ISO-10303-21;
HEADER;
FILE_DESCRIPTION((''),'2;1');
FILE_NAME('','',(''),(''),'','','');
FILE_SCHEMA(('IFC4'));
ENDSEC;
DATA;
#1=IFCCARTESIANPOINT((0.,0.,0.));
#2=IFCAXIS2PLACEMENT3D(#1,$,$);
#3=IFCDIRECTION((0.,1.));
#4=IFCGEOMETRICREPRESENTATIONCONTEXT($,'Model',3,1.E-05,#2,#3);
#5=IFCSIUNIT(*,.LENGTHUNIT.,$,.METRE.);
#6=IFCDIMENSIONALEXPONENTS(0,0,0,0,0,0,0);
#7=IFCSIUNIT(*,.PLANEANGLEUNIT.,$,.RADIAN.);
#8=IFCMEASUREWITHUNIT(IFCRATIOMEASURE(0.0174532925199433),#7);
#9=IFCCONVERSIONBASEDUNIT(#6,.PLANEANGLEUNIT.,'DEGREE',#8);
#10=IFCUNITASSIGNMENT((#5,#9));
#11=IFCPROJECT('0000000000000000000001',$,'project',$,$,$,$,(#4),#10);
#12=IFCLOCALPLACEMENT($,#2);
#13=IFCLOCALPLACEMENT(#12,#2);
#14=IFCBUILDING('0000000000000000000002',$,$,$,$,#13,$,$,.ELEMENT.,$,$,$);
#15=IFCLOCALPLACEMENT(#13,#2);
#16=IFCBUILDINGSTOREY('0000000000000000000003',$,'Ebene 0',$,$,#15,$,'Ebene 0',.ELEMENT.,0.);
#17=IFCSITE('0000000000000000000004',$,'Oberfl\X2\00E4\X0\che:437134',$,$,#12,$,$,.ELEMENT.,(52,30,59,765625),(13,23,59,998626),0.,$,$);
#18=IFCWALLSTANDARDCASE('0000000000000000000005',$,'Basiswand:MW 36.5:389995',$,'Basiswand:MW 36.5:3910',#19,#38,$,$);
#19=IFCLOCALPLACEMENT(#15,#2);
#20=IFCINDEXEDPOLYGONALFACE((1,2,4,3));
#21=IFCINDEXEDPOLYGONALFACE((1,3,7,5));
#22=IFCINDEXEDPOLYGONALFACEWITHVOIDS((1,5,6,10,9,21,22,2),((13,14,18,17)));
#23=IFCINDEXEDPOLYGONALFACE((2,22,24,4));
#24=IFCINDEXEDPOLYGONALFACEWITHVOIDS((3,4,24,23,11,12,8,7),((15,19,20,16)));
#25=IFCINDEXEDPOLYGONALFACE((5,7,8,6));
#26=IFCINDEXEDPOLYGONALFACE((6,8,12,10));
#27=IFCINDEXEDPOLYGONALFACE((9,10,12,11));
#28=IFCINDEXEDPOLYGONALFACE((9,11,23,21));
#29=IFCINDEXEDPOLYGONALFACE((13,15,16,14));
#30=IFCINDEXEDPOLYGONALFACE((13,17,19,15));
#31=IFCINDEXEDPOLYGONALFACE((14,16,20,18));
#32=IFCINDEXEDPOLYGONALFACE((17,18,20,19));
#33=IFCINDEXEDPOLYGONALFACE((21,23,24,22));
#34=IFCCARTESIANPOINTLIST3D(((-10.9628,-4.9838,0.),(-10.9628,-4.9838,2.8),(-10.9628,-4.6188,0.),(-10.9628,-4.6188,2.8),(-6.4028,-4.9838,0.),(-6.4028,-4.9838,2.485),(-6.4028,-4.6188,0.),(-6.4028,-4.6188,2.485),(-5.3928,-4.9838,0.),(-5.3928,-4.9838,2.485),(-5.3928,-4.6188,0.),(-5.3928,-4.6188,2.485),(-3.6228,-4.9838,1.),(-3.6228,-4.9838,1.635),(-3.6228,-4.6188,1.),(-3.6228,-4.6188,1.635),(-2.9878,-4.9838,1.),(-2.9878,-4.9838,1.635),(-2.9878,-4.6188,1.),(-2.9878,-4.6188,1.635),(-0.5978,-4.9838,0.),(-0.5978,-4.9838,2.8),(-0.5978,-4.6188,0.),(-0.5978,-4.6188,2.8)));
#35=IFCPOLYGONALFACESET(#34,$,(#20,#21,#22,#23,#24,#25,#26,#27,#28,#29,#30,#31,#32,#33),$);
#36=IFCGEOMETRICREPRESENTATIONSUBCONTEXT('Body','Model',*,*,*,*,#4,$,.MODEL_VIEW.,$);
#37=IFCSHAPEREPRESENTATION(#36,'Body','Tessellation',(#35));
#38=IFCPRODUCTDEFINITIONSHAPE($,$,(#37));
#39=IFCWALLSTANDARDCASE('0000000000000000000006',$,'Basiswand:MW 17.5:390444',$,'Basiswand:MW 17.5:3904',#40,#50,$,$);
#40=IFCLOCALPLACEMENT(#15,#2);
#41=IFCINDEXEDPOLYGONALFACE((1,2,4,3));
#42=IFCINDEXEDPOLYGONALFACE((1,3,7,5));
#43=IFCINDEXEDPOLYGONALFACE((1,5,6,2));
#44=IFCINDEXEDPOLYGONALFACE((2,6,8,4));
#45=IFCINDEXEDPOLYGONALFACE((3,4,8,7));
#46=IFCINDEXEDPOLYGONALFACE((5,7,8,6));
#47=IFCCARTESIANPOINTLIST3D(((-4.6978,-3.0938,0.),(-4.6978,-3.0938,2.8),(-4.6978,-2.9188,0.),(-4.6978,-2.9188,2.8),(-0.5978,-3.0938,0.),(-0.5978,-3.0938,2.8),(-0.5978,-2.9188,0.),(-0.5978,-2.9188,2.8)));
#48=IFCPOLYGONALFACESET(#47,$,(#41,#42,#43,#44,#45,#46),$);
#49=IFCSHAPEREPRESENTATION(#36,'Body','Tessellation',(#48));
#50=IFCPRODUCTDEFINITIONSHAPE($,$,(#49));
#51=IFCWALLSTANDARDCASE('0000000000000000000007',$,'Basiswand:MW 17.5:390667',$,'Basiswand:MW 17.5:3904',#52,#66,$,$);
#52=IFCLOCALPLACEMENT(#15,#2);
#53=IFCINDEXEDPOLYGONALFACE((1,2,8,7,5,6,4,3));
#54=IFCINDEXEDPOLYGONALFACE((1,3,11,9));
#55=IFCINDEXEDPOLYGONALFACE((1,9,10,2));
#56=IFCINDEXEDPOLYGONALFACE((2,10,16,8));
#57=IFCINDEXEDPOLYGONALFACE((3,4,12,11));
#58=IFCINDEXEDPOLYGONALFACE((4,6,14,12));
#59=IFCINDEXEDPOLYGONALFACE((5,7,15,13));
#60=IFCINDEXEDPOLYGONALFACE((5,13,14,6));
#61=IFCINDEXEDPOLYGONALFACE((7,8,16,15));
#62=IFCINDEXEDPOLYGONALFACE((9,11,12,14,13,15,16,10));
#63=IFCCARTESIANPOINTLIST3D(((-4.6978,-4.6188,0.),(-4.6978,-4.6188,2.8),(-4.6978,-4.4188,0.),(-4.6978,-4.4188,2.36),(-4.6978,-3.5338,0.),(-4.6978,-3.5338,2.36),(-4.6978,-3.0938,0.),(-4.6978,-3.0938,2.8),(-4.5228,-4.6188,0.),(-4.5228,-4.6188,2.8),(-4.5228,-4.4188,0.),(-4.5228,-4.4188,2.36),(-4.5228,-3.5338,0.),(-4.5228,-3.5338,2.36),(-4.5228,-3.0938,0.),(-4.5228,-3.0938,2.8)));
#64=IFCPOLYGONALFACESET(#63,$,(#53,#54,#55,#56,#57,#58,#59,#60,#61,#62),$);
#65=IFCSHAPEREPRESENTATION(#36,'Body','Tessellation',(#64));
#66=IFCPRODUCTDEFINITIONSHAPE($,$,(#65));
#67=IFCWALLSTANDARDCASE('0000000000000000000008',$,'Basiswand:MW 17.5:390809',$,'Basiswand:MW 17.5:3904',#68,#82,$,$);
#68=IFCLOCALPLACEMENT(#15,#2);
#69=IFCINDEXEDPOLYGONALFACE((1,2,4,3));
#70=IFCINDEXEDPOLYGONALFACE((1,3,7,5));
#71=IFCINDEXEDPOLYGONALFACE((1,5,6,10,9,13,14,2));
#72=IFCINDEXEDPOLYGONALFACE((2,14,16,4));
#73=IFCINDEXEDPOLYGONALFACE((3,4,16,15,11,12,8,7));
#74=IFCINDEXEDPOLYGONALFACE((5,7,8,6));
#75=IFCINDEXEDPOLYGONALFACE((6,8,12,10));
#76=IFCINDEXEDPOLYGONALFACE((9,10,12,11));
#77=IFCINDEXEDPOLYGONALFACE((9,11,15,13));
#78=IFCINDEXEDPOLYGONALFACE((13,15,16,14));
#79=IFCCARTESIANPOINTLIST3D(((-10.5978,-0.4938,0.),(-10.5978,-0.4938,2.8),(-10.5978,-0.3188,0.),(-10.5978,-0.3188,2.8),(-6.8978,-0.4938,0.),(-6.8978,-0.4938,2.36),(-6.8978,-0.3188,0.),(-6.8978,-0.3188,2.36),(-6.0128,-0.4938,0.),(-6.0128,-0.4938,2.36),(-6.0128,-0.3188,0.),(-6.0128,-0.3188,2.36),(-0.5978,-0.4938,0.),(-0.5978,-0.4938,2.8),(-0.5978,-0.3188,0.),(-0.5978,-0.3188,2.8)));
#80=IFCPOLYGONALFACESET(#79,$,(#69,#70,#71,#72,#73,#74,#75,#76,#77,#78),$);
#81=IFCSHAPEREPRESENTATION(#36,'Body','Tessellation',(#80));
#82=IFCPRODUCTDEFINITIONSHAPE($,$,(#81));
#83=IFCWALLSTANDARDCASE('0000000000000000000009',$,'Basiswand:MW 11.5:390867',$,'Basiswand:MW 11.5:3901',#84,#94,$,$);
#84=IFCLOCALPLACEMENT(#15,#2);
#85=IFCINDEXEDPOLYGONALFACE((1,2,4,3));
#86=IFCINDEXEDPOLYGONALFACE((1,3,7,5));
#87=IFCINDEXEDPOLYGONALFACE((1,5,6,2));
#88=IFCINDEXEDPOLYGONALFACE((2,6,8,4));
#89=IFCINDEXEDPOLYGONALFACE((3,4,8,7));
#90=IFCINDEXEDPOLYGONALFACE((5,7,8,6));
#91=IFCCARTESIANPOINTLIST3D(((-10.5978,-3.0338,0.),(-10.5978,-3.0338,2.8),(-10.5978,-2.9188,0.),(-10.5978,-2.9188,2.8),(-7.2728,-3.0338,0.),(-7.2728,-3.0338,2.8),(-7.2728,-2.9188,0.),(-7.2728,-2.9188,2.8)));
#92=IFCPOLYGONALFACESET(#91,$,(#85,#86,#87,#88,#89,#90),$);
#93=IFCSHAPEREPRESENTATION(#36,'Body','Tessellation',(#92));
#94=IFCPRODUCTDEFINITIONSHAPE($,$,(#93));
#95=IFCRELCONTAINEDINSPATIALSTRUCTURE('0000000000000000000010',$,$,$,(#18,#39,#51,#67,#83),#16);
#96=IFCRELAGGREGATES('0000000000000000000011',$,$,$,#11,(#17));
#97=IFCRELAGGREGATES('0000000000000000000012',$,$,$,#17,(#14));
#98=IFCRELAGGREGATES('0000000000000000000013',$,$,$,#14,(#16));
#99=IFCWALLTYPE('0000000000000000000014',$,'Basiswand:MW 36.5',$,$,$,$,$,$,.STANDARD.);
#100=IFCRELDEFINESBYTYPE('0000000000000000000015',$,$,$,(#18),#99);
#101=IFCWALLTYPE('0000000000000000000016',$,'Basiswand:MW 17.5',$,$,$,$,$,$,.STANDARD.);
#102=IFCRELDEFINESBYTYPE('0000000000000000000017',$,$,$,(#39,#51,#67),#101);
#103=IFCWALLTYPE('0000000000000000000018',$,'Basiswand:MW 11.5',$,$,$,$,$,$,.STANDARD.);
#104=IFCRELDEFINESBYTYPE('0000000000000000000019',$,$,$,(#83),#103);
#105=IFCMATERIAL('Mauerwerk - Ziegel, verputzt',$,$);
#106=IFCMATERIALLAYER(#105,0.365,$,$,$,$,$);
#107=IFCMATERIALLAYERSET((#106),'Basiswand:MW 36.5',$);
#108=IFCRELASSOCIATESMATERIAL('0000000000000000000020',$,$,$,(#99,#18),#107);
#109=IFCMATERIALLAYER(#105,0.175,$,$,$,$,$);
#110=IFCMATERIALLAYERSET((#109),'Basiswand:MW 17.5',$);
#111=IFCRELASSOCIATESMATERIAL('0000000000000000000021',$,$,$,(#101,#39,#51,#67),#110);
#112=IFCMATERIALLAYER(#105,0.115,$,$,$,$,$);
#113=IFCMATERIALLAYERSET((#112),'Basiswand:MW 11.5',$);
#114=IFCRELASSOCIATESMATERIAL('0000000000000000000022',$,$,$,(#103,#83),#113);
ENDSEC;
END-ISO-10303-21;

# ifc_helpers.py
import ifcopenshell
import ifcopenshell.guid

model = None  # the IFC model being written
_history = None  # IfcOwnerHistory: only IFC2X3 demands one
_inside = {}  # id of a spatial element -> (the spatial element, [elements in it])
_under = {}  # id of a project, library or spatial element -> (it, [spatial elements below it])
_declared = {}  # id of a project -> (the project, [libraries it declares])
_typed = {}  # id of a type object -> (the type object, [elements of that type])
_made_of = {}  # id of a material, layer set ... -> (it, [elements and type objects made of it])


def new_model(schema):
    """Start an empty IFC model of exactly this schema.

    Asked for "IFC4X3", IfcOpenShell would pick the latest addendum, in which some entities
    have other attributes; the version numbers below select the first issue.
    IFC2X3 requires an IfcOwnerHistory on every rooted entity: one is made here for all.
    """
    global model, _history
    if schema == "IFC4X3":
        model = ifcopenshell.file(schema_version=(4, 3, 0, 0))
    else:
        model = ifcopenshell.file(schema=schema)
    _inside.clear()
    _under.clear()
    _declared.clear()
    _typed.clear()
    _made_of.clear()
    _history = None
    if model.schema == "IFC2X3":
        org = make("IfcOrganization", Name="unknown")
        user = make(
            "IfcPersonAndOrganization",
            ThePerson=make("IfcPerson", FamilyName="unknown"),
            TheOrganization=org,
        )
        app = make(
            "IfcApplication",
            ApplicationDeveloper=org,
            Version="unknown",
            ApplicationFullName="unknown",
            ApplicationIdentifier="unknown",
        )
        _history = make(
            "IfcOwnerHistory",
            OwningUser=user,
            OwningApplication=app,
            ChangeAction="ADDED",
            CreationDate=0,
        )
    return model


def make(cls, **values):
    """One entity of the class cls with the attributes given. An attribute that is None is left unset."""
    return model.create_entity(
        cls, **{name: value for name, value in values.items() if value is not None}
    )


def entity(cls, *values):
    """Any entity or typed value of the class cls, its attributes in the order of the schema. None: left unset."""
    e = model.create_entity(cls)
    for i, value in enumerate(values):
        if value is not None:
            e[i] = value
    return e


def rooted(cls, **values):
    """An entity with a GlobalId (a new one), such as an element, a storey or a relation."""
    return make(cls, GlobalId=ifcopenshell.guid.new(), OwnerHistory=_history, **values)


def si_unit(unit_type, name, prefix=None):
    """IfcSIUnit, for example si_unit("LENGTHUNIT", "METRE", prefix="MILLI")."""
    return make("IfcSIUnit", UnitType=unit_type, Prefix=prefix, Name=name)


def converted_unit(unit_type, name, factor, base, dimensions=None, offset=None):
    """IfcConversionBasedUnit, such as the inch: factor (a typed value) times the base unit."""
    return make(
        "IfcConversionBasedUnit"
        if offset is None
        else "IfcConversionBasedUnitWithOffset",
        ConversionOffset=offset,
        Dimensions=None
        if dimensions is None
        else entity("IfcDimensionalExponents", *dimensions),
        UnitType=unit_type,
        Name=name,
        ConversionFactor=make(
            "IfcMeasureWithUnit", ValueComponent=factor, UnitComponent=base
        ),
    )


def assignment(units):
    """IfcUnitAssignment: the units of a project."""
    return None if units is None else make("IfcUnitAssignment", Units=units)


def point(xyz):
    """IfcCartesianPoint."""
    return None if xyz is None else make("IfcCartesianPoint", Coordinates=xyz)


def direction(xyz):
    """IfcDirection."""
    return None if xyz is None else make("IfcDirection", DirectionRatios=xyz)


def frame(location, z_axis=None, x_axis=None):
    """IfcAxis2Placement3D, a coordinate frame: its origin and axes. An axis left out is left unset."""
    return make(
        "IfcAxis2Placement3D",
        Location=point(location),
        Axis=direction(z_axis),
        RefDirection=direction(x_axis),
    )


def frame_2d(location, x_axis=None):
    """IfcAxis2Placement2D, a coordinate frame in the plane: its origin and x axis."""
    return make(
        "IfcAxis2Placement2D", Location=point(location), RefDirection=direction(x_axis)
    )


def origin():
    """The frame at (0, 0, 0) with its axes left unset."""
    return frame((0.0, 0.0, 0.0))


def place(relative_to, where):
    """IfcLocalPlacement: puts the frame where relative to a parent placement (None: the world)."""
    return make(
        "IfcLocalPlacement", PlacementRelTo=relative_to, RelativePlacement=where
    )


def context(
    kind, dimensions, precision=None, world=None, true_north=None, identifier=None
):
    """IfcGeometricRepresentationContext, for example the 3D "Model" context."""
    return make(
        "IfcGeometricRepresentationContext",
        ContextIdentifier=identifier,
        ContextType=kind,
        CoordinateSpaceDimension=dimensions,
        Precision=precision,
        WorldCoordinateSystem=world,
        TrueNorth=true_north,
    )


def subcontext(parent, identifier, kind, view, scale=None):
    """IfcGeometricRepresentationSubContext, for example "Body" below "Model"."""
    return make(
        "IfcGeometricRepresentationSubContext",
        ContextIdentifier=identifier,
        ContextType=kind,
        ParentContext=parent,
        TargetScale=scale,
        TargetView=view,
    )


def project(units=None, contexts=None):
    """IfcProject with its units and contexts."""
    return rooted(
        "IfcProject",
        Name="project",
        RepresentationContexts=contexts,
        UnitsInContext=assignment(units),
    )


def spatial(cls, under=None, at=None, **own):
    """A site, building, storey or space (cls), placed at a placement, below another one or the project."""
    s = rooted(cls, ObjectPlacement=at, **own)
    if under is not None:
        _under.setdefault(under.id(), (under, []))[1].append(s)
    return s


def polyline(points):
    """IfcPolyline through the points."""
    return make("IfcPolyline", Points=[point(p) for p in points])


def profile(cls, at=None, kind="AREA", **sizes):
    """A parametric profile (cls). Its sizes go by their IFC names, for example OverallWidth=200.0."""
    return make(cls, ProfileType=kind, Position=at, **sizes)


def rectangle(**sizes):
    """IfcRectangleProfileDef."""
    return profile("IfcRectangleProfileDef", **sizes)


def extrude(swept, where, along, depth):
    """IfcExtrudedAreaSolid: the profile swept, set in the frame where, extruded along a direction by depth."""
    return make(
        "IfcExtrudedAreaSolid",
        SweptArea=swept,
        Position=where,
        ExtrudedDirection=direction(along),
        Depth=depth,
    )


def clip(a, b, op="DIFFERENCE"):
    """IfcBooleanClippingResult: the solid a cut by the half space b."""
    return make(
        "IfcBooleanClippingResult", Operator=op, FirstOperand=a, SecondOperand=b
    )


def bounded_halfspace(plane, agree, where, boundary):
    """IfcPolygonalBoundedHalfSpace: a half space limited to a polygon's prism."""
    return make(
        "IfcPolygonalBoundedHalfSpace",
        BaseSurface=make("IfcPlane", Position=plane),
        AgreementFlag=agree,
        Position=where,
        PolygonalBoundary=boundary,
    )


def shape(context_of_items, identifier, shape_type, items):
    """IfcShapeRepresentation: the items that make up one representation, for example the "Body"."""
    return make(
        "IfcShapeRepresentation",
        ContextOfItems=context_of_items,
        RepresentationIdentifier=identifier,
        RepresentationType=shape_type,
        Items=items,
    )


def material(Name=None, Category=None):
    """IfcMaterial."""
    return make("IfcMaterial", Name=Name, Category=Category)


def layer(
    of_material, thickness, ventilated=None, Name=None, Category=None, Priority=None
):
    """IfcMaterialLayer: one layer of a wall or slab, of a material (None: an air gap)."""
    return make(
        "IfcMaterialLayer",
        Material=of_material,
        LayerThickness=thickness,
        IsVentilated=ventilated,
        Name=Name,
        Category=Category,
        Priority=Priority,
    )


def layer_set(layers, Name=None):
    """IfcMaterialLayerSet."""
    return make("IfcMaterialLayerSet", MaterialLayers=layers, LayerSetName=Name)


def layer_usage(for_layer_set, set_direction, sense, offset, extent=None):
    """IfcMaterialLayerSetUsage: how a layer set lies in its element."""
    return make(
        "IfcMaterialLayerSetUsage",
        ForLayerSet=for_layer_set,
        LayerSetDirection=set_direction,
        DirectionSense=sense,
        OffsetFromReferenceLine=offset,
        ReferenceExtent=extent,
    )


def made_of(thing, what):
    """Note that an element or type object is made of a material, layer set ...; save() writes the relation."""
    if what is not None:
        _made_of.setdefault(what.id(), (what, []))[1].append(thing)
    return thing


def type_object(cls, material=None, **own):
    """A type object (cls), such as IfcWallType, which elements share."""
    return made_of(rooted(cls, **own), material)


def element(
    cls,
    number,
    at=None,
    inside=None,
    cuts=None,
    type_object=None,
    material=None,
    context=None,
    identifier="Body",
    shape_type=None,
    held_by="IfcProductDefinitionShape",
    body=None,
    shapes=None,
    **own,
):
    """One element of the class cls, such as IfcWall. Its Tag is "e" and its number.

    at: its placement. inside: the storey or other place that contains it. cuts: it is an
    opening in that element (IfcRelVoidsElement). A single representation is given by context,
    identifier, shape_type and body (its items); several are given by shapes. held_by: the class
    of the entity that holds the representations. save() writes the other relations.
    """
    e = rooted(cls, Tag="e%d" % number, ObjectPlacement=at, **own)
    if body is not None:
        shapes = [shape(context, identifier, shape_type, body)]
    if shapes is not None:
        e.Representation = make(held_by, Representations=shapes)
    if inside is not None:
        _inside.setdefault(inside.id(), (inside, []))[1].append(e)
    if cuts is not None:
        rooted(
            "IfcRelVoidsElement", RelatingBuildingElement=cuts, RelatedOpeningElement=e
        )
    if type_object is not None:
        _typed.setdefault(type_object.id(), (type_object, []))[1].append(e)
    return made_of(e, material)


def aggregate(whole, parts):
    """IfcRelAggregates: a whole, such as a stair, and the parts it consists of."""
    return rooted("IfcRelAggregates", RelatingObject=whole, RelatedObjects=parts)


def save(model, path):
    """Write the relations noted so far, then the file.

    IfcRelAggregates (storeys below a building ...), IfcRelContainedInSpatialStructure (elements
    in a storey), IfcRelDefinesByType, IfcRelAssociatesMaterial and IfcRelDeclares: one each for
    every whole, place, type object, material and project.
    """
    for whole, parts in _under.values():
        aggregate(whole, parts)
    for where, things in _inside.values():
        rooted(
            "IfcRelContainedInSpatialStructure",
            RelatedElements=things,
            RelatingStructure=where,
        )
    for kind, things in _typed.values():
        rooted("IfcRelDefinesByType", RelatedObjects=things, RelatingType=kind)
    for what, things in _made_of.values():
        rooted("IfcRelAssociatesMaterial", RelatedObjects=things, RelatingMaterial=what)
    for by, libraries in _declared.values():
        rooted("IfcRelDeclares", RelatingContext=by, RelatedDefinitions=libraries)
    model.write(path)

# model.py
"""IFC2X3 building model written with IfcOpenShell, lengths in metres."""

from ifc_helpers import new_model, entity, si_unit, converted_unit, direction, frame, frame_2d, origin, place, context, subcontext, project, spatial, polyline, rectangle, extrude, clip, bounded_halfspace, material, layer, layer_set, layer_usage, type_object, element, save


model = new_model("IFC2X3")

# Units and contexts
model_context = context("Model", 3, precision=1e-05, world=origin(), true_north=direction((0.0, 1.0)))
body_context = subcontext(model_context, "Body", "Model", "MODEL_VIEW")
ifc_project = project(units=[si_unit("LENGTHUNIT", "METRE"), converted_unit("PLANEANGLEUNIT", "DEGREE", entity("IfcRatioMeasure", 0.0174532925199433), si_unit("PLANEANGLEUNIT", "RADIAN"), dimensions=[0, 0, 0, 0, 0, 0, 0])], contexts=[model_context])

# Site, building, storey
site_placement = place(None, origin())
site = spatial("IfcSite", under=ifc_project, at=site_placement, Name="Oberfläche:437134", CompositionType="ELEMENT", RefLatitude=(52, 30, 59, 765625), RefLongitude=(13, 23, 59, 998626), RefElevation=0.0)
building_placement = place(site_placement, origin())
building = spatial("IfcBuilding", under=site, at=building_placement, CompositionType="ELEMENT")
storey_placement = place(building_placement, origin())
storey = spatial("IfcBuildingStorey", under=building, at=storey_placement, Name="Ebene 0", LongName="Ebene 0", CompositionType="ELEMENT", Elevation=0.0)

# Wall, openings
ifc_material_1 = material(Name="Mauerwerk - Ziegel, verputzt")
ifc_layer_1 = layer(ifc_material_1, 0.365)
ifc_layer_set_1 = layer_set([ifc_layer_1], Name="Basiswand:MW 36.5")
wall_type_1 = type_object("IfcWallType", Name="Basiswand:MW 36.5", PredefinedType="STANDARD", material=ifc_layer_set_1)
ifc_layer_usage_1 = layer_usage(ifc_layer_set_1, "AXIS2", "NEGATIVE", 0.1825)
wall_1_placement = place(storey_placement, frame((-0.5978, -4.8013, 0.0), z_axis=(0.0, 0.0, 1.0), x_axis=(-1.0, 0.0, 0.0)))
wall_1 = element("IfcWallStandardCase", 1, at=wall_1_placement, inside=storey, type_object=wall_type_1, material=ifc_layer_usage_1, Name="Basiswand:MW 36.5:389995", ObjectType="Basiswand:MW 36.5:3910", context=body_context, shape_type="Clipping", body=[
    clip(extrude(rectangle(XDim=10.365, YDim=0.365, at=frame_2d((5.1825, 0.0), x_axis=(-1.0, 0.0))), origin(), (0.0, 0.0, 1.0), 2.8), bounded_halfspace(frame((0.0, -0.1825, 2.8), z_axis=(0.0, 0.0, -1.0), x_axis=(0.0, -1.0, 0.0)), True, frame((0.0, -0.1825, 2.8)), polyline([(0.0, 0.0), (3.925, 0.0), (4.1, 0.0), (6.5, 0.0), (6.675, 0.0), (10.0, 0.0), (10.365, 0.0), (10.365, 0.365), (0.0, 0.365), (0.0, 0.0)]))),
])
opening_1_placement = place(wall_1_placement, frame((5.805, 0.1825, 0.0)))
element("IfcOpeningElement", 2, at=opening_1_placement, cuts=wall_1, ObjectType="Opening", context=body_context, shape_type="SweptSolid", body=[
    extrude(rectangle(XDim=2.485, YDim=1.01, at=frame_2d((1.2425, 0.505), x_axis=(1.0, 0.0))), frame((0.0, 0.0, 0.0), z_axis=(0.0, -1.0, 0.0), x_axis=(0.0, 0.0, 1.0)), (0.0, 0.0, 1.0), 0.365),
])
opening_2_placement = place(wall_1_placement, frame((3.025, 0.1825, 1.0)))
element("IfcOpeningElement", 3, at=opening_2_placement, cuts=wall_1, ObjectType="Opening", context=body_context, shape_type="SweptSolid", body=[
    extrude(rectangle(XDim=0.635, YDim=0.635, at=frame_2d((0.3175, 0.3175), x_axis=(1.0, 0.0))), frame((0.0, 0.0, 0.0), z_axis=(0.0, -1.0, 0.0), x_axis=(0.0, 0.0, 1.0)), (0.0, 0.0, 1.0), 0.365),
])

# Wall
ifc_layer_2 = layer(ifc_material_1, 0.175)
ifc_layer_set_2 = layer_set([ifc_layer_2], Name="Basiswand:MW 17.5")
ifc_layer_usage_2 = layer_usage(ifc_layer_set_2, "AXIS2", "NEGATIVE", 0.0875)
wall_type_2 = type_object("IfcWallType", Name="Basiswand:MW 17.5", PredefinedType="STANDARD", material=ifc_layer_set_2)
wall_2_placement = place(storey_placement, frame((-0.5978, -3.0063, 0.0), z_axis=(0.0, 0.0, 1.0), x_axis=(-1.0, 0.0, 0.0)))
element("IfcWallStandardCase", 4, at=wall_2_placement, inside=storey, type_object=wall_type_2, material=ifc_layer_usage_2, Name="Basiswand:MW 17.5:390444", ObjectType="Basiswand:MW 17.5:3904", context=body_context, shape_type="Clipping", body=[
    clip(extrude(rectangle(XDim=4.1, YDim=0.175, at=frame_2d((2.05, 0.0), x_axis=(-1.0, 0.0))), origin(), (0.0, 0.0, 1.0), 2.8), bounded_halfspace(frame((0.0, -0.0875, 2.8), z_axis=(0.0, 0.0, -1.0), x_axis=(0.0, -1.0, 0.0)), True, frame((0.0, -0.0875, 2.8)), polyline([(0.0, 0.0), (1.3, 0.0), (4.1, 0.0), (4.1, 0.175), (3.925, 0.175), (0.0, 0.175), (0.0, 0.0)]))),
])

# Walls, openings
ifc_layer_usage_3 = layer_usage(ifc_layer_set_2, "AXIS2", "NEGATIVE", 0.0875)
wall_3_placement = place(storey_placement, frame((-4.6103, -3.0938, 0.0), z_axis=(0.0, 0.0, 1.0), x_axis=(0.0, -1.0, 0.0)))
wall_3 = element("IfcWallStandardCase", 5, at=wall_3_placement, inside=storey, type_object=wall_type_2, material=ifc_layer_usage_3, Name="Basiswand:MW 17.5:390667", ObjectType="Basiswand:MW 17.5:3904", context=body_context, shape_type="Clipping", body=[
    clip(extrude(rectangle(XDim=1.525, YDim=0.175, at=frame_2d((0.7625, 0.0), x_axis=(-1.0, 0.0))), origin(), (0.0, 0.0, 1.0), 2.8), bounded_halfspace(frame((0.0, -0.0875, 2.8), z_axis=(0.0, 0.0, -1.0), x_axis=(-1.0, 0.0, 0.0)), True, frame((0.0, -0.0875, 2.8)), polyline([(0.0, 0.0), (1.525, 0.0), (1.525, 0.175), (0.0, 0.175), (0.0, 0.0)]))),
])
opening_3_placement = place(wall_3_placement, frame((0.44, -0.0875, 0.0)))
element("IfcOpeningElement", 6, at=opening_3_placement, cuts=wall_3, ObjectType="Opening", context=body_context, shape_type="SweptSolid", body=[
    extrude(rectangle(XDim=2.36, YDim=0.885, at=frame_2d((1.18, 0.4425), x_axis=(1.0, 0.0))), frame((0.0, 0.0, 0.0), z_axis=(0.0, 1.0, 0.0), x_axis=(0.0, 0.0, 1.0)), (0.0, 0.0, 1.0), 0.175),
])
ifc_layer_usage_4 = layer_usage(ifc_layer_set_2, "AXIS2", "NEGATIVE", 0.0875)
wall_4_placement = place(storey_placement, frame((-0.5978, -0.4063, 0.0), z_axis=(0.0, 0.0, 1.0), x_axis=(-1.0, 0.0, 0.0)))
wall_4 = element("IfcWallStandardCase", 7, at=wall_4_placement, inside=storey, type_object=wall_type_2, material=ifc_layer_usage_4, Name="Basiswand:MW 17.5:390809", ObjectType="Basiswand:MW 17.5:3904", context=body_context, shape_type="Clipping", body=[
    clip(extrude(rectangle(XDim=10.0, YDim=0.175, at=frame_2d((5.0, 0.0), x_axis=(-1.0, 0.0))), origin(), (0.0, 0.0, 1.0), 2.8), bounded_halfspace(frame((0.0, -0.0875, 2.8), z_axis=(0.0, 0.0, -1.0), x_axis=(0.0, -1.0, 0.0)), True, frame((0.0, -0.0875, 2.8)), polyline([(0.0, 0.0), (10.0, 0.0), (10.0, 0.175), (6.675, 0.175), (6.5, 0.175), (0.0, 0.175), (0.0, 0.0)]))),
])
opening_4_placement = place(wall_4_placement, frame((6.3, 0.0875, 0.0)))
element("IfcOpeningElement", 8, at=opening_4_placement, cuts=wall_4, ObjectType="Opening", context=body_context, shape_type="SweptSolid", body=[
    extrude(rectangle(XDim=2.36, YDim=0.885, at=frame_2d((1.18, 0.4425), x_axis=(1.0, 0.0))), frame((0.0, 0.0, 0.0), z_axis=(0.0, -1.0, 0.0), x_axis=(0.0, 0.0, 1.0)), (0.0, 0.0, 1.0), 0.175),
])

# Wall
ifc_layer_3 = layer(ifc_material_1, 0.115)
ifc_layer_set_3 = layer_set([ifc_layer_3], Name="Basiswand:MW 11.5")
ifc_layer_usage_5 = layer_usage(ifc_layer_set_3, "AXIS2", "NEGATIVE", 0.0575)
wall_type_3 = type_object("IfcWallType", Name="Basiswand:MW 11.5", PredefinedType="STANDARD", material=ifc_layer_set_3)
wall_5_placement = place(storey_placement, frame((-7.2728, -2.9763, 0.0), z_axis=(0.0, 0.0, 1.0), x_axis=(-1.0, 0.0, 0.0)))
element("IfcWallStandardCase", 9, at=wall_5_placement, inside=storey, type_object=wall_type_3, material=ifc_layer_usage_5, Name="Basiswand:MW 11.5:390867", ObjectType="Basiswand:MW 11.5:3901", context=body_context, shape_type="Clipping", body=[
    clip(extrude(rectangle(XDim=3.325, YDim=0.115, at=frame_2d((1.6625, 0.0), x_axis=(-1.0, 0.0))), origin(), (0.0, 0.0, 1.0), 2.8), bounded_halfspace(frame((0.0, -0.0575, 2.8), z_axis=(0.0, 0.0, -1.0), x_axis=(0.0, -1.0, 0.0)), True, frame((0.0, -0.0575, 2.8)), polyline([(0.0, 0.0), (3.325, 0.0), (3.325, 0.115), (0.0, 0.115), (0.0, 0.0)]))),
])

save(model, "model.ifc")
